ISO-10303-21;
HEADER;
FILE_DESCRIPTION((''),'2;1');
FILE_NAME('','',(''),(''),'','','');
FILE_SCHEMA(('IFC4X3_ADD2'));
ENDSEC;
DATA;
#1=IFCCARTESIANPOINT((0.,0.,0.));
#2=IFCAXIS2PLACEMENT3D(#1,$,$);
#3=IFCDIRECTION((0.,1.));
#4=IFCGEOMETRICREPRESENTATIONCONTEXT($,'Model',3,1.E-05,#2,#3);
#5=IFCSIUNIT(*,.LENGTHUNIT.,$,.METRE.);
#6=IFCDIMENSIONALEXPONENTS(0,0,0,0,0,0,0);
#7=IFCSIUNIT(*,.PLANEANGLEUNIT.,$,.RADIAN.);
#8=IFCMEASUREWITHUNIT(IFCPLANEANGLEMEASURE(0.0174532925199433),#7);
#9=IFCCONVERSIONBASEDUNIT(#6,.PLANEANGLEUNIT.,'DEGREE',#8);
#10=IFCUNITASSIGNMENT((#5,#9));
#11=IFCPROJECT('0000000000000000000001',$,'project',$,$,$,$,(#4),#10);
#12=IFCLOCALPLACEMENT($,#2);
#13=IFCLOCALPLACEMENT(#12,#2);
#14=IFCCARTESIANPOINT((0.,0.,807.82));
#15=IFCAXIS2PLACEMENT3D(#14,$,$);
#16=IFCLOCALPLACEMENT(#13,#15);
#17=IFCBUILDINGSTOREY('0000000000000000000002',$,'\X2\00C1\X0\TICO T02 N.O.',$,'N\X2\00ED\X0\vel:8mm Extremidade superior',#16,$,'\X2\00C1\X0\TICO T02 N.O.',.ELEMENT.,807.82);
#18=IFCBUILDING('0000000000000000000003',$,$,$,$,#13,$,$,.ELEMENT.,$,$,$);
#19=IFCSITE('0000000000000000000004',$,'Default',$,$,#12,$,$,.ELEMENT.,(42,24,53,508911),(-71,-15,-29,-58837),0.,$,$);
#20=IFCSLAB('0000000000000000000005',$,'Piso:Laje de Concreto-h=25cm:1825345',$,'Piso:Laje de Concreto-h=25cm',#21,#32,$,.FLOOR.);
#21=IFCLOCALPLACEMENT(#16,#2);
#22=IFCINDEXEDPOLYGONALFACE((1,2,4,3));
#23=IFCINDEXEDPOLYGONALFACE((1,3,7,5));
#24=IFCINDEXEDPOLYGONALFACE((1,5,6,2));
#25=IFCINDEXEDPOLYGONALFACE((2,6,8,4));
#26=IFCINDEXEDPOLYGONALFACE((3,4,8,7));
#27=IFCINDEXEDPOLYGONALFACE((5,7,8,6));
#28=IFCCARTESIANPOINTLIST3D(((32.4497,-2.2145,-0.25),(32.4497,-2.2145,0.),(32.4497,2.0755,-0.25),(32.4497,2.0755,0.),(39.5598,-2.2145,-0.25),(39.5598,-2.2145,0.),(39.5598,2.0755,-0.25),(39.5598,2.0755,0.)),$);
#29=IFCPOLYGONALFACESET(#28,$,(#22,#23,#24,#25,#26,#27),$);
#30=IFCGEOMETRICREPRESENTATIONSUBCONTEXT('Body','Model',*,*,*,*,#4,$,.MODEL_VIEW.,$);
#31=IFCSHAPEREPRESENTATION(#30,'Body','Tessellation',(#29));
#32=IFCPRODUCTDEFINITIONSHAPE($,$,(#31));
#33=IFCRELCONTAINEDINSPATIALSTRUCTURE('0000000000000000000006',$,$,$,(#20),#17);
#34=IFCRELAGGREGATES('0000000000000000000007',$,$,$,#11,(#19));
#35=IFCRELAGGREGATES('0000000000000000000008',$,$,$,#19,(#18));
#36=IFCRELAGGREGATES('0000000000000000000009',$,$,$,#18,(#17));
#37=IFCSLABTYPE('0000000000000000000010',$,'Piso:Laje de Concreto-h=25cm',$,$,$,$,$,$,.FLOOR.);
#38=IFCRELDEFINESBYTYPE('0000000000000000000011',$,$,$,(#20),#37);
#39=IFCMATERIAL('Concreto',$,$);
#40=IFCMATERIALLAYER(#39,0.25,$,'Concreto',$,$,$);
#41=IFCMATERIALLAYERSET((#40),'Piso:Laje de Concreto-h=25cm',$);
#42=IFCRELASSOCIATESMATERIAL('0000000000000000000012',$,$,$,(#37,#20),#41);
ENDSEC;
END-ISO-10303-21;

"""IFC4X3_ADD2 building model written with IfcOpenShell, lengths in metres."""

from ifc_helpers import new_model, entity, si_unit, converted_unit, direction, frame, frame_2d, origin, place, context, subcontext, project, spatial, rectangle, extrude, material, layer, layer_set, layer_usage, type_object, element, save


model = new_model("IFC4X3_ADD2")

# Units and contexts
model_context = context("Model", 3, precision=1e-05, world=origin(), true_north=direction((0.0, 1.0)))
body_context = subcontext(model_context, "Body", "Model", "MODEL_VIEW")
ifc_project = project(units=[si_unit("LENGTHUNIT", "METRE"), converted_unit("PLANEANGLEUNIT", "DEGREE", entity("IfcPlaneAngleMeasure", 0.0174532925199433), si_unit("PLANEANGLEUNIT", "RADIAN"), dimensions=[0, 0, 0, 0, 0, 0, 0])], contexts=[model_context])

# Site, building, storey
site_placement = place(None, origin())
site = spatial("IfcSite", under=ifc_project, at=site_placement, Name="Default", CompositionType="ELEMENT", RefLatitude=(42, 24, 53, 508911), RefLongitude=(-71, -15, -29, -58837), RefElevation=0.0)
building_placement = place(site_placement, origin())
building = spatial("IfcBuilding", under=site, at=building_placement, CompositionType="ELEMENT")
storey_placement = place(building_placement, frame((0.0, 0.0, 807.82)))
storey = spatial("IfcBuildingStorey", under=building, at=storey_placement, Name="ÁTICO T02 N.O.", ObjectType="Nível:8mm Extremidade superior", LongName="ÁTICO T02 N.O.", CompositionType="ELEMENT", Elevation=807.82)

# Shared definitions
ifc_material = material(Name="Concreto")

# Slab
ifc_layer_1 = layer(ifc_material, 0.25, Name="Concreto")
ifc_layer_set_1 = layer_set([ifc_layer_1], Name="Piso:Laje de Concreto-h=25cm")
ifc_layer_usage_1 = layer_usage(ifc_layer_set_1, "AXIS3", "POSITIVE", 0.0)
slab_type_1 = type_object("IfcSlabType", Name="Piso:Laje de Concreto-h=25cm", PredefinedType="FLOOR", material=ifc_layer_set_1)
slab_1_placement = place(storey_placement, origin())
element("IfcSlab", 1, at=slab_1_placement, inside=storey, type_object=slab_type_1, material=ifc_layer_usage_1, Name="Piso:Laje de Concreto-h=25cm:1825345", ObjectType="Piso:Laje de Concreto-h=25cm", PredefinedType="FLOOR", context=body_context, shape_type="SweptSolid", body=[
    extrude(rectangle(XDim=4.29, YDim=7.1101, at=frame_2d((0.0, 0.0), x_axis=(1.0, 0.0))), frame((36.0048, -0.0695, 0.0), z_axis=(0.0, 0.0, -1.0), x_axis=(0.0, 1.0, 0.0)), (0.0, 0.0, 1.0), 0.25),
])

save(model, "model.ifc")
